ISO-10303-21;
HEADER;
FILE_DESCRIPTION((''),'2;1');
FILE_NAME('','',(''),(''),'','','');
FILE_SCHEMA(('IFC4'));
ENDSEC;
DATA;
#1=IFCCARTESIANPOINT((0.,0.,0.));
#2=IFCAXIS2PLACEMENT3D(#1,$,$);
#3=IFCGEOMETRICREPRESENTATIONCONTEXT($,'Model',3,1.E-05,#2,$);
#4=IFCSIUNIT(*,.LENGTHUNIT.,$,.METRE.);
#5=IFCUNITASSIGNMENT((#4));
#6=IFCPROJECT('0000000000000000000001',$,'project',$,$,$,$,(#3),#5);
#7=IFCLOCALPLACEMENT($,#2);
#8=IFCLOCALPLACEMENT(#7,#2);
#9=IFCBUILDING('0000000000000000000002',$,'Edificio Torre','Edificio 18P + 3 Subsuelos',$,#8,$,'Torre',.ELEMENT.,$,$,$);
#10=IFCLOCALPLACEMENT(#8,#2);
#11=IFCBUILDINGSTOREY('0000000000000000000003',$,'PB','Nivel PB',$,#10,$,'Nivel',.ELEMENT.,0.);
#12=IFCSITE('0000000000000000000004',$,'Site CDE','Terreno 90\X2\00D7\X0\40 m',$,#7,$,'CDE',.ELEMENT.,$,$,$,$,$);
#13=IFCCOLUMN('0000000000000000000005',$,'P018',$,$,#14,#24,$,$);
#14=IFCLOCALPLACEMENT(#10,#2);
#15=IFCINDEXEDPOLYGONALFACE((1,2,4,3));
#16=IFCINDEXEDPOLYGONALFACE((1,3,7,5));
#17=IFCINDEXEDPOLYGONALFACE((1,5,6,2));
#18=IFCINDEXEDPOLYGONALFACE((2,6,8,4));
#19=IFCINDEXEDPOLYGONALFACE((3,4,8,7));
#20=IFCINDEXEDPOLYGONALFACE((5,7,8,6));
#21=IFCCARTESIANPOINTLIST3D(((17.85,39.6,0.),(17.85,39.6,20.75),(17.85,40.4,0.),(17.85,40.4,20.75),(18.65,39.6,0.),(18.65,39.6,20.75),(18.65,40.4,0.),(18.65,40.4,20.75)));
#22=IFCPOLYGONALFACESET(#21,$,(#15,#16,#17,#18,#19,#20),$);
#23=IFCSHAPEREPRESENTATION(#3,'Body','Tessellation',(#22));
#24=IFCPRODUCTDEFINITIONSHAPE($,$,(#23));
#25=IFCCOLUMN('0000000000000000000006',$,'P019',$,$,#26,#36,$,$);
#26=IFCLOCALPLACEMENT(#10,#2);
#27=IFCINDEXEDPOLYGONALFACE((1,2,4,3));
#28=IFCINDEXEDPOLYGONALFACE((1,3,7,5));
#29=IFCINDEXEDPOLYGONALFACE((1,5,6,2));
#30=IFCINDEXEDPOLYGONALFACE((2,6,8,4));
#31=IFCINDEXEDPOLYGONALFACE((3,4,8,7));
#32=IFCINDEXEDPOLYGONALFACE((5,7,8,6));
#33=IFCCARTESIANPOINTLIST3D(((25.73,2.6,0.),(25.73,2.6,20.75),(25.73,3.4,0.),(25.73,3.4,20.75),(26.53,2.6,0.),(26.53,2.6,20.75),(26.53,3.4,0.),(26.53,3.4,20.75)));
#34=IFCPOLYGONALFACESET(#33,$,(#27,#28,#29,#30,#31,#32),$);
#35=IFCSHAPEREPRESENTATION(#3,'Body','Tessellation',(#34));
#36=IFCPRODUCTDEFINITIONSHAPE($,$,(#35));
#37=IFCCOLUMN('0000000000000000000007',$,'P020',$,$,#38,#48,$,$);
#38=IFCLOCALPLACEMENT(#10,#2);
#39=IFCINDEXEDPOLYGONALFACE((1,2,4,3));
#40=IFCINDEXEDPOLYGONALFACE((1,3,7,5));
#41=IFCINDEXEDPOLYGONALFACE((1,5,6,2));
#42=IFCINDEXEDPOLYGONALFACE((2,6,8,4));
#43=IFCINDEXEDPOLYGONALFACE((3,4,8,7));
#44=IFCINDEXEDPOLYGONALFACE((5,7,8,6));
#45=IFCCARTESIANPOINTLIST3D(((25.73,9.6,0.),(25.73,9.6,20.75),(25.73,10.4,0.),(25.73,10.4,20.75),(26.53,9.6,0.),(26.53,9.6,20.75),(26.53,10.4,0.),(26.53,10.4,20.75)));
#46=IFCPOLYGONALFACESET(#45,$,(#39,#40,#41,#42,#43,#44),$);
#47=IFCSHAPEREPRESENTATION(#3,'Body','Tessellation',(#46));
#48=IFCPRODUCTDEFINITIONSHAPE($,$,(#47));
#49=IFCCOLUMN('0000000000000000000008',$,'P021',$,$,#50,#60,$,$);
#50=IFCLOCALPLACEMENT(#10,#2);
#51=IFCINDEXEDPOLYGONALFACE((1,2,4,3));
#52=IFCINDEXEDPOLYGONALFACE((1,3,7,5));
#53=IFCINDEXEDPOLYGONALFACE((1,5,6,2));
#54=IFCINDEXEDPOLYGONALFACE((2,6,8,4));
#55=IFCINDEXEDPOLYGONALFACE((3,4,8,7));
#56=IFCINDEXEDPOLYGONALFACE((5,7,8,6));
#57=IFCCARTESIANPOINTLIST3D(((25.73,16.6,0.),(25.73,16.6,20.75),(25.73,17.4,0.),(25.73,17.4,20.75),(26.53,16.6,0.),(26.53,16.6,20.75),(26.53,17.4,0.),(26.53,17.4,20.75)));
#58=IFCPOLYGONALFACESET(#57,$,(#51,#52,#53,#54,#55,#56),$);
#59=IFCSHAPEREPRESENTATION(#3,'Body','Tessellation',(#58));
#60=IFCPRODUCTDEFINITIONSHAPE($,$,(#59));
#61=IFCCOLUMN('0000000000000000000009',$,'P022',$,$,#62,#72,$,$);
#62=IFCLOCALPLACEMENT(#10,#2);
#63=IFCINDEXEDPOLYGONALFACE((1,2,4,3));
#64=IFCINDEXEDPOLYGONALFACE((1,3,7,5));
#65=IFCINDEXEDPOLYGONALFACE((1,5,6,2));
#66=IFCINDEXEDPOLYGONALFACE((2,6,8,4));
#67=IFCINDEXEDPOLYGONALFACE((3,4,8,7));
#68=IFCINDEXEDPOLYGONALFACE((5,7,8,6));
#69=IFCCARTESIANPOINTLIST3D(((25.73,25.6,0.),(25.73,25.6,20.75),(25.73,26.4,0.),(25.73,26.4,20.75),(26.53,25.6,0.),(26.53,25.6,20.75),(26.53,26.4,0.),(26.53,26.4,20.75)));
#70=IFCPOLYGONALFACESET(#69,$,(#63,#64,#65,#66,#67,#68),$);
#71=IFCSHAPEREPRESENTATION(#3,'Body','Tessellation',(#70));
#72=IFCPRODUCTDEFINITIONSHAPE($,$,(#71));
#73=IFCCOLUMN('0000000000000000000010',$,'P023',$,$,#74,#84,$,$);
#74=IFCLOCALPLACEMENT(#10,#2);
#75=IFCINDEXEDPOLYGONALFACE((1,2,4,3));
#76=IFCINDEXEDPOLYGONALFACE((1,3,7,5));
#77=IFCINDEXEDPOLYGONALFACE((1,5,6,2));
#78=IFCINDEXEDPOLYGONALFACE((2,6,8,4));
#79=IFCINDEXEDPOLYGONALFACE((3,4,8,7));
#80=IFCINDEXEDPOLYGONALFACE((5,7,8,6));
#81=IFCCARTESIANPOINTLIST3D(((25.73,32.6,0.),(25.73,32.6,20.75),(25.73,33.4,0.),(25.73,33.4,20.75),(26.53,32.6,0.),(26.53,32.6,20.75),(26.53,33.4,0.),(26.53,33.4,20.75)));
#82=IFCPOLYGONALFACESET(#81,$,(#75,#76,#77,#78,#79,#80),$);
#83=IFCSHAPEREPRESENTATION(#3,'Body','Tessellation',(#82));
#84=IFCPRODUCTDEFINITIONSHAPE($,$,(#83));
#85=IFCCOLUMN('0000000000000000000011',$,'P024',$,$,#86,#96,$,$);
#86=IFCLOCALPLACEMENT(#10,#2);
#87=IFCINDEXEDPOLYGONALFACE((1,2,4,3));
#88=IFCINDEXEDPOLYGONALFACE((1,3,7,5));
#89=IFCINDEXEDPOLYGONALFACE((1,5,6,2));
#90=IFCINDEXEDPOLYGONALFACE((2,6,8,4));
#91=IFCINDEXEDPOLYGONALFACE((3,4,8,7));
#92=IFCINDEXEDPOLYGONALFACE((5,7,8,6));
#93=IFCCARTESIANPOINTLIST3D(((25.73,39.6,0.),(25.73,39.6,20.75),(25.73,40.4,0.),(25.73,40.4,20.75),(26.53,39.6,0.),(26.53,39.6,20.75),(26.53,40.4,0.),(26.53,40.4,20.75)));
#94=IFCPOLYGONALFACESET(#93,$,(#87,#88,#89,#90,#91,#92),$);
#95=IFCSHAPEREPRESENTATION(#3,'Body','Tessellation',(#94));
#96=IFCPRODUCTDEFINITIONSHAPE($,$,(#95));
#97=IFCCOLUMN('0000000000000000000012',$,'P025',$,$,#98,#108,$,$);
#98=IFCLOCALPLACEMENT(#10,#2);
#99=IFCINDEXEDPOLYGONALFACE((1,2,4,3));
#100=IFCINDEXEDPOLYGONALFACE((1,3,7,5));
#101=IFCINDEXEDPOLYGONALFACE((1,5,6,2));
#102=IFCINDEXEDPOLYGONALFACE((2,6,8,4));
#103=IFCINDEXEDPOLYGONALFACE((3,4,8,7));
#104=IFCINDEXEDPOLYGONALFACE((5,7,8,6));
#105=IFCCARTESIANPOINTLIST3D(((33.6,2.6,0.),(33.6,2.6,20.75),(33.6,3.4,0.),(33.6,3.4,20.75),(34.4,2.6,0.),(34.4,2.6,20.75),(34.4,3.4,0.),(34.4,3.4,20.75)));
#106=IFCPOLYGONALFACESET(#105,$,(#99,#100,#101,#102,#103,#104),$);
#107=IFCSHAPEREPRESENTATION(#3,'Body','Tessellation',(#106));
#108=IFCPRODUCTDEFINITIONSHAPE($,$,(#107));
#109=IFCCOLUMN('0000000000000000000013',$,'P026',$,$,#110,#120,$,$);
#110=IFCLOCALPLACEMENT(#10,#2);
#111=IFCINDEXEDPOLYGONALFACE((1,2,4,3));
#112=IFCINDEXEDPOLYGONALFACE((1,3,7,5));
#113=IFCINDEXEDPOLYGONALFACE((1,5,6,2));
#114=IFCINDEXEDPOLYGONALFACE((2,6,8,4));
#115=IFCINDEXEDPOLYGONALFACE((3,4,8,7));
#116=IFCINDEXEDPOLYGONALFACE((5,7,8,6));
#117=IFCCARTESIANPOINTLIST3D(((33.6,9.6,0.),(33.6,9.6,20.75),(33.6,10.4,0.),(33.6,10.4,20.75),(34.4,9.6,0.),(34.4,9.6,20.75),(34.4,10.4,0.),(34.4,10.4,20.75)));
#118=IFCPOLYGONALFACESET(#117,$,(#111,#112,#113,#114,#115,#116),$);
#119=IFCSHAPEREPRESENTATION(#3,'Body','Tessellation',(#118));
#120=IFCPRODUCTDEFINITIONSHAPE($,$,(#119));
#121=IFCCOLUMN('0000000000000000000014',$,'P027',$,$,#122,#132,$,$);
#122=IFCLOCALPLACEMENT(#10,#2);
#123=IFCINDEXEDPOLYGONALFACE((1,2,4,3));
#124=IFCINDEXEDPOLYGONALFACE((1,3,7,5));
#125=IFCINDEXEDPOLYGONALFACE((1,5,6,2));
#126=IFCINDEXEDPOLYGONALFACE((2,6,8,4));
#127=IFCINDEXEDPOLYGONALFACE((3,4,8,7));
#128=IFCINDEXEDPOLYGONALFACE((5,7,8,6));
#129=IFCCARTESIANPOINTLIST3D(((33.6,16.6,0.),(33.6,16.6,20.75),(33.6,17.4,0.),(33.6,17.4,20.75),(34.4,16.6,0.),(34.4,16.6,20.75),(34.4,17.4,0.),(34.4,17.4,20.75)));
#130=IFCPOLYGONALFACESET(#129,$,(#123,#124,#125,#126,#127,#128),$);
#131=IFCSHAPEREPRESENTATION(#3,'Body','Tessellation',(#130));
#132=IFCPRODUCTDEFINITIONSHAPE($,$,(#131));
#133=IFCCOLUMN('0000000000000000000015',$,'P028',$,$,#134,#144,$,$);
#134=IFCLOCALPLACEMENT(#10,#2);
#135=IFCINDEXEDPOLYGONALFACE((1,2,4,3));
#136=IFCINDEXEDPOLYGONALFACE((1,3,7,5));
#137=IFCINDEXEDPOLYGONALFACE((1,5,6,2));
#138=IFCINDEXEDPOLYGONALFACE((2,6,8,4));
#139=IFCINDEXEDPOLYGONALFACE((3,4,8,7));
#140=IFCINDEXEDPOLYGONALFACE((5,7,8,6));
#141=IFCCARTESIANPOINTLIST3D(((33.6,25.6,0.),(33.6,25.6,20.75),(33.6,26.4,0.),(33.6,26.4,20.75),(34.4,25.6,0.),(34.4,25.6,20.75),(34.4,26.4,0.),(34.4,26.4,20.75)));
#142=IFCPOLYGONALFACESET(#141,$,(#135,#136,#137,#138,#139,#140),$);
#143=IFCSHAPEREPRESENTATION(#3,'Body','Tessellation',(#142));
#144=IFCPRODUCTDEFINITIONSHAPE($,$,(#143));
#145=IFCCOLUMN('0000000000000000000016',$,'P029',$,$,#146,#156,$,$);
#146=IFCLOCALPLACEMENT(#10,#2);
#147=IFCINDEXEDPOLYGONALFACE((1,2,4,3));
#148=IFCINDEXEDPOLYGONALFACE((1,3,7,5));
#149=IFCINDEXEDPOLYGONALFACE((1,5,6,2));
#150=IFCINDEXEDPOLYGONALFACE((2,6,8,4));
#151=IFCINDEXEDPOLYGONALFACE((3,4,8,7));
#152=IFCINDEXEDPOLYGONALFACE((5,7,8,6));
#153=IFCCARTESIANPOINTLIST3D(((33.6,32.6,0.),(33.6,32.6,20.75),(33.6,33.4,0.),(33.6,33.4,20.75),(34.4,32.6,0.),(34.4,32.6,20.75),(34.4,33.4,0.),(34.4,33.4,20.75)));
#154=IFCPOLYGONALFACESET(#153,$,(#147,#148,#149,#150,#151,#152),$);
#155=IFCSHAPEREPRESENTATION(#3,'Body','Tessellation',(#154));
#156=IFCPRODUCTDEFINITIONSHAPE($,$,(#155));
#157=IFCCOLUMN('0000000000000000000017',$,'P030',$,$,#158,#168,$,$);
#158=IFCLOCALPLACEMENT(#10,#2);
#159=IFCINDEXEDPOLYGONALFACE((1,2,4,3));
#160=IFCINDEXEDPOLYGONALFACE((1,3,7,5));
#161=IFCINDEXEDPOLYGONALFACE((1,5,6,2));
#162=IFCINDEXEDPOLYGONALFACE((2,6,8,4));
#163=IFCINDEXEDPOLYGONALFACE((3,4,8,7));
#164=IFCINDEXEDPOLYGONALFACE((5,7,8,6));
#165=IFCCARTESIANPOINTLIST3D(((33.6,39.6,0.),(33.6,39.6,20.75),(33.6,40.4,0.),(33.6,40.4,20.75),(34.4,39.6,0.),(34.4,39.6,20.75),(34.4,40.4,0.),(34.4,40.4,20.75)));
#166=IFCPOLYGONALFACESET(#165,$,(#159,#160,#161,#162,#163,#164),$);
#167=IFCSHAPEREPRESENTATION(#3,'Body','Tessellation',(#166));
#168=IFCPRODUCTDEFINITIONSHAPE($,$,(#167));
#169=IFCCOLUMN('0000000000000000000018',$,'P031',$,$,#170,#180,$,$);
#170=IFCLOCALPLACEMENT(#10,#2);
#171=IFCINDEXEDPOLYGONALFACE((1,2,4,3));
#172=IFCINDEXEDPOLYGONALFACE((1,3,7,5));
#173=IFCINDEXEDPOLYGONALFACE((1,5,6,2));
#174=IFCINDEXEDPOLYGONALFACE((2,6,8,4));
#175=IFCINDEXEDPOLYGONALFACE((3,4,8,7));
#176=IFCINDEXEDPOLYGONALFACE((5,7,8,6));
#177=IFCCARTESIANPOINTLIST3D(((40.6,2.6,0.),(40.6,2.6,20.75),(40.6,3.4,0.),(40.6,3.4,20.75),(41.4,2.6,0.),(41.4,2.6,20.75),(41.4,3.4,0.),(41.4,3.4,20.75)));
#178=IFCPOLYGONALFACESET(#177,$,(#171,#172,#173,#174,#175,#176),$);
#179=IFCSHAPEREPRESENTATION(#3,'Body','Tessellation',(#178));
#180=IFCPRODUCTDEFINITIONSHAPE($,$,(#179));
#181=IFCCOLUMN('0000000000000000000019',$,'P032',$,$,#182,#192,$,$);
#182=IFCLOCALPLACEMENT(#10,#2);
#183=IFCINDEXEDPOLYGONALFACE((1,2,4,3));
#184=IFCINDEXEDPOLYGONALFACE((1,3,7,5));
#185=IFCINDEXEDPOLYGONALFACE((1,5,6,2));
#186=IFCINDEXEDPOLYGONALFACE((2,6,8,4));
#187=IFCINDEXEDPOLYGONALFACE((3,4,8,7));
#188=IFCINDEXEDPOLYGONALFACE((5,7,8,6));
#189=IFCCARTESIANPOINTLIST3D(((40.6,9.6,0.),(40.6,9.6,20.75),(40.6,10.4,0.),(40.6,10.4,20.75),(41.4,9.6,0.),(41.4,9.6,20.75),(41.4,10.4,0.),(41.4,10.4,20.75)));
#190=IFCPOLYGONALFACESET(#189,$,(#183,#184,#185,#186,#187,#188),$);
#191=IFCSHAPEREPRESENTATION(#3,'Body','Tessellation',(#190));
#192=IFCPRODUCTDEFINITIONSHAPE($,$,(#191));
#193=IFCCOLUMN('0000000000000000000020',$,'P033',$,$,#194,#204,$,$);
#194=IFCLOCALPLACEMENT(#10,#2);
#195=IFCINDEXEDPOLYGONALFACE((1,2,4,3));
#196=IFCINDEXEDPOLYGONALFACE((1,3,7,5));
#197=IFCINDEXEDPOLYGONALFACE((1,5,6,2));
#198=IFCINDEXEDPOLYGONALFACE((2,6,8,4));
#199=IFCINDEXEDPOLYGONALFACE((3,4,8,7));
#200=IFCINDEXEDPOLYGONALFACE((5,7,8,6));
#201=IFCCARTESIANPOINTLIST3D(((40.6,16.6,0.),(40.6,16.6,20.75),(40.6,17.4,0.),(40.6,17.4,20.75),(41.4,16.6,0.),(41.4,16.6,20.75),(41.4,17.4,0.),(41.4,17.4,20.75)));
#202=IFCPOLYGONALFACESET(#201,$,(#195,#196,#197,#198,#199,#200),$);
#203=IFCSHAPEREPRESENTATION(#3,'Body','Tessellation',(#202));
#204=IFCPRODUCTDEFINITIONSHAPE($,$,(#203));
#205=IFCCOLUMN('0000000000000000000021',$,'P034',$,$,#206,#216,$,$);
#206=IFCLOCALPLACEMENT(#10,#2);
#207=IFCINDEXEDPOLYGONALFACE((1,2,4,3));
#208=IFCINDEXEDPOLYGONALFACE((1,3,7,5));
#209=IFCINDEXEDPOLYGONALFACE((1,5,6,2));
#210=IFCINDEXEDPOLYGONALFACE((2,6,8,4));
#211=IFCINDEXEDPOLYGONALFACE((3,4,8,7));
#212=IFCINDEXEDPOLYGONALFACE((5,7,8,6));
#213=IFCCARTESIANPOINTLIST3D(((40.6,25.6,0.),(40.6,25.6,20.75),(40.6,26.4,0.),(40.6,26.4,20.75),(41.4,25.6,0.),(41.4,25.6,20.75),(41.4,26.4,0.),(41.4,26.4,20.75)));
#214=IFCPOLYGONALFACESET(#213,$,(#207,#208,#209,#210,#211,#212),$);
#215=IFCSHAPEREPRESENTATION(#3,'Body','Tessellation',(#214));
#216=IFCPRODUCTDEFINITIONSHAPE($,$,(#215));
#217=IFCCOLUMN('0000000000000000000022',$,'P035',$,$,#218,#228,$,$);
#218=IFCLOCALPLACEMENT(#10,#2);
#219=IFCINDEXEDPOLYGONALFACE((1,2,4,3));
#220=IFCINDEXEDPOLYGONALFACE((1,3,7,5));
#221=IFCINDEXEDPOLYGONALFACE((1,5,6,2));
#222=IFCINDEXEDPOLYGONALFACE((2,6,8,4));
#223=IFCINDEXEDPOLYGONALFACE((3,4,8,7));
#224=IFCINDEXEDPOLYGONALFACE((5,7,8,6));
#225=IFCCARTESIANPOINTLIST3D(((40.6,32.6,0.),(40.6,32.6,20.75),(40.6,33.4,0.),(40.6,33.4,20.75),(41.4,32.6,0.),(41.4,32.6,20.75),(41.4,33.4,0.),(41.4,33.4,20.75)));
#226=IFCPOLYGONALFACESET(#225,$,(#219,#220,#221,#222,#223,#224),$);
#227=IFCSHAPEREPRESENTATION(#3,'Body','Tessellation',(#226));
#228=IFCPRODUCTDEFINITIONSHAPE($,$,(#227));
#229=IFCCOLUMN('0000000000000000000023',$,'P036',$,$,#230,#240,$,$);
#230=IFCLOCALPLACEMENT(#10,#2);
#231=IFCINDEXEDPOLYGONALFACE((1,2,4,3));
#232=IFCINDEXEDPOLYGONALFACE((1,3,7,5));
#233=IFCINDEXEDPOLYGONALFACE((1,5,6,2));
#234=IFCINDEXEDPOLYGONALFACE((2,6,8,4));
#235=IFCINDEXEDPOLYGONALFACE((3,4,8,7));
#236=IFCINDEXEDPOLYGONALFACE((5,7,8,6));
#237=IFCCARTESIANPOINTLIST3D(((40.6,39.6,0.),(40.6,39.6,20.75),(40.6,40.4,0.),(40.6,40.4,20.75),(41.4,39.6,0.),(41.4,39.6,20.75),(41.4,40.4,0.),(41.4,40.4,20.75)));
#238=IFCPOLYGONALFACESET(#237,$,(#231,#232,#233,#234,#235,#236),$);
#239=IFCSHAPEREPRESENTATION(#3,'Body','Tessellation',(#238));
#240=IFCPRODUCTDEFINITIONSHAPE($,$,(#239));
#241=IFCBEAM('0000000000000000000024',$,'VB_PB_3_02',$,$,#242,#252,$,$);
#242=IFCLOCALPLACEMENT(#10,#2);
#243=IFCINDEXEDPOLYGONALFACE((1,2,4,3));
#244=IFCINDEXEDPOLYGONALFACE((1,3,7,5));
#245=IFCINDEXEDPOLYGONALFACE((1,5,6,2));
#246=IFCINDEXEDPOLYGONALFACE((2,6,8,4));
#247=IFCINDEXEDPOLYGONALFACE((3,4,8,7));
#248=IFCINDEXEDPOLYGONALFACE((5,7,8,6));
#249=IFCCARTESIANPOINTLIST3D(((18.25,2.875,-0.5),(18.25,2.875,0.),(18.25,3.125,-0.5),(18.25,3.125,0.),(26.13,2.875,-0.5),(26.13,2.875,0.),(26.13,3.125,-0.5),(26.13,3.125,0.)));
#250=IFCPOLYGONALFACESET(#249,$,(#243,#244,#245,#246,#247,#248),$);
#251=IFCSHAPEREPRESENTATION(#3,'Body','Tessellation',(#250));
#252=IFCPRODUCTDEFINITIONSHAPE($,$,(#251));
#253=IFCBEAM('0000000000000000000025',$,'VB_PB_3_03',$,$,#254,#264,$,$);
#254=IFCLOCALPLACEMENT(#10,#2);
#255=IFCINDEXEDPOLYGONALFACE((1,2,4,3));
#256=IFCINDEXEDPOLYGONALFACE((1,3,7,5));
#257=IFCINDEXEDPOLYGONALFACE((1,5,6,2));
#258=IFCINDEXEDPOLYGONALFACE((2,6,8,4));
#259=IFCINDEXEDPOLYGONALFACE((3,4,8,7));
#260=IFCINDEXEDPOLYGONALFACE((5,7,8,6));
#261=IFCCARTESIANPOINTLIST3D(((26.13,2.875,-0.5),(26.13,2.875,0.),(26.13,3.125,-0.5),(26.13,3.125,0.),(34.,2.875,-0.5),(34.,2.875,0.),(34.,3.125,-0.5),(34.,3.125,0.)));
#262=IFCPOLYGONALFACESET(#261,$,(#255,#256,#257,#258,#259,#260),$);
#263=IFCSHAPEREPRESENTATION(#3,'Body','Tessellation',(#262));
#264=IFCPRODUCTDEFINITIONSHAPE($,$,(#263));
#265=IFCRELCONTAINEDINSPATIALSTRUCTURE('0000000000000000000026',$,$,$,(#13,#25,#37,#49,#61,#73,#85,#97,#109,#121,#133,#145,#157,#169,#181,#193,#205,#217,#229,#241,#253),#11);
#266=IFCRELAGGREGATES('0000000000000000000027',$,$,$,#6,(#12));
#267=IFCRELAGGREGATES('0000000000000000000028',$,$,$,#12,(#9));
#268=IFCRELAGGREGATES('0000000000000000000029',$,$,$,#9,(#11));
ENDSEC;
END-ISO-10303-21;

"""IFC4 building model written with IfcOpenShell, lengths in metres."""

from ifc_helpers import new_model, si_unit, frame, origin, origin_2d, place, context, project, spatial, rectangle, extrude, element, save


model = new_model("IFC4")

# Units and contexts
model_context = context("Model", 3, precision=1e-05, world=origin())
ifc_project = project(units=[si_unit("LENGTHUNIT", "METRE")], contexts=[model_context])

# Site, building, storey
site_placement = place(None, origin())
site = spatial("IfcSite", under=ifc_project, at=site_placement, Name="Site CDE", Description="Terreno 90×40 m", LongName="CDE", CompositionType="ELEMENT")
building_placement = place(site_placement, origin())
building = spatial("IfcBuilding", under=site, at=building_placement, Name="Edificio Torre", Description="Edificio 18P + 3 Subsuelos", LongName="Torre", CompositionType="ELEMENT")
storey_placement = place(building_placement, origin())
storey = spatial("IfcBuildingStorey", under=building, at=storey_placement, Name="PB", Description="Nivel PB", LongName="Nivel", CompositionType="ELEMENT", Elevation=0.0)

# Columns
for number, where, name in (
    (1, (18.25, 40.0, 0.0), "P018"),
    (2, (26.13, 3.0, 0.0), "P019"),
    (3, (26.13, 10.0, 0.0), "P020"),
    (4, (26.13, 17.0, 0.0), "P021"),
    (5, (26.13, 26.0, 0.0), "P022"),
    (6, (26.13, 33.0, 0.0), "P023"),
    (7, (26.13, 40.0, 0.0), "P024"),
    (8, (34.0, 3.0, 0.0), "P025"),
    (9, (34.0, 10.0, 0.0), "P026"),
    (10, (34.0, 17.0, 0.0), "P027"),
    (11, (34.0, 26.0, 0.0), "P028"),
    (12, (34.0, 33.0, 0.0), "P029"),
    (13, (34.0, 40.0, 0.0), "P030"),
    (14, (41.0, 3.0, 0.0), "P031"),
    (15, (41.0, 10.0, 0.0), "P032"),
    (16, (41.0, 17.0, 0.0), "P033"),
    (17, (41.0, 26.0, 0.0), "P034"),
    (18, (41.0, 33.0, 0.0), "P035"),
    (19, (41.0, 40.0, 0.0), "P036"),
):
    element("IfcColumn", number, at=place(storey_placement, frame(where)), inside=storey, Name=name, context=model_context, shape_type="SweptSolid", body=[
        extrude(rectangle(XDim=0.8, YDim=0.8, at=origin_2d()), origin(), (0.0, 0.0, 1.0), 20.75),
    ])

# Beams
beam_1_placement = place(storey_placement, frame((22.19, 3.0, -0.5)))
element("IfcBeam", 20, at=beam_1_placement, inside=storey, Name="VB_PB_3_02", context=model_context, shape_type="SweptSolid", body=[
    extrude(rectangle(XDim=7.88, YDim=0.25, at=origin_2d()), origin(), (0.0, 0.0, 1.0), 0.5),
])
beam_2_placement = place(storey_placement, frame((30.065, 3.0, -0.5)))
element("IfcBeam", 21, at=beam_2_placement, inside=storey, Name="VB_PB_3_03", context=model_context, shape_type="SweptSolid", body=[
    extrude(rectangle(XDim=7.87, YDim=0.25, at=origin_2d()), origin(), (0.0, 0.0, 1.0), 0.5),
])

save(model, "model.ifc")
